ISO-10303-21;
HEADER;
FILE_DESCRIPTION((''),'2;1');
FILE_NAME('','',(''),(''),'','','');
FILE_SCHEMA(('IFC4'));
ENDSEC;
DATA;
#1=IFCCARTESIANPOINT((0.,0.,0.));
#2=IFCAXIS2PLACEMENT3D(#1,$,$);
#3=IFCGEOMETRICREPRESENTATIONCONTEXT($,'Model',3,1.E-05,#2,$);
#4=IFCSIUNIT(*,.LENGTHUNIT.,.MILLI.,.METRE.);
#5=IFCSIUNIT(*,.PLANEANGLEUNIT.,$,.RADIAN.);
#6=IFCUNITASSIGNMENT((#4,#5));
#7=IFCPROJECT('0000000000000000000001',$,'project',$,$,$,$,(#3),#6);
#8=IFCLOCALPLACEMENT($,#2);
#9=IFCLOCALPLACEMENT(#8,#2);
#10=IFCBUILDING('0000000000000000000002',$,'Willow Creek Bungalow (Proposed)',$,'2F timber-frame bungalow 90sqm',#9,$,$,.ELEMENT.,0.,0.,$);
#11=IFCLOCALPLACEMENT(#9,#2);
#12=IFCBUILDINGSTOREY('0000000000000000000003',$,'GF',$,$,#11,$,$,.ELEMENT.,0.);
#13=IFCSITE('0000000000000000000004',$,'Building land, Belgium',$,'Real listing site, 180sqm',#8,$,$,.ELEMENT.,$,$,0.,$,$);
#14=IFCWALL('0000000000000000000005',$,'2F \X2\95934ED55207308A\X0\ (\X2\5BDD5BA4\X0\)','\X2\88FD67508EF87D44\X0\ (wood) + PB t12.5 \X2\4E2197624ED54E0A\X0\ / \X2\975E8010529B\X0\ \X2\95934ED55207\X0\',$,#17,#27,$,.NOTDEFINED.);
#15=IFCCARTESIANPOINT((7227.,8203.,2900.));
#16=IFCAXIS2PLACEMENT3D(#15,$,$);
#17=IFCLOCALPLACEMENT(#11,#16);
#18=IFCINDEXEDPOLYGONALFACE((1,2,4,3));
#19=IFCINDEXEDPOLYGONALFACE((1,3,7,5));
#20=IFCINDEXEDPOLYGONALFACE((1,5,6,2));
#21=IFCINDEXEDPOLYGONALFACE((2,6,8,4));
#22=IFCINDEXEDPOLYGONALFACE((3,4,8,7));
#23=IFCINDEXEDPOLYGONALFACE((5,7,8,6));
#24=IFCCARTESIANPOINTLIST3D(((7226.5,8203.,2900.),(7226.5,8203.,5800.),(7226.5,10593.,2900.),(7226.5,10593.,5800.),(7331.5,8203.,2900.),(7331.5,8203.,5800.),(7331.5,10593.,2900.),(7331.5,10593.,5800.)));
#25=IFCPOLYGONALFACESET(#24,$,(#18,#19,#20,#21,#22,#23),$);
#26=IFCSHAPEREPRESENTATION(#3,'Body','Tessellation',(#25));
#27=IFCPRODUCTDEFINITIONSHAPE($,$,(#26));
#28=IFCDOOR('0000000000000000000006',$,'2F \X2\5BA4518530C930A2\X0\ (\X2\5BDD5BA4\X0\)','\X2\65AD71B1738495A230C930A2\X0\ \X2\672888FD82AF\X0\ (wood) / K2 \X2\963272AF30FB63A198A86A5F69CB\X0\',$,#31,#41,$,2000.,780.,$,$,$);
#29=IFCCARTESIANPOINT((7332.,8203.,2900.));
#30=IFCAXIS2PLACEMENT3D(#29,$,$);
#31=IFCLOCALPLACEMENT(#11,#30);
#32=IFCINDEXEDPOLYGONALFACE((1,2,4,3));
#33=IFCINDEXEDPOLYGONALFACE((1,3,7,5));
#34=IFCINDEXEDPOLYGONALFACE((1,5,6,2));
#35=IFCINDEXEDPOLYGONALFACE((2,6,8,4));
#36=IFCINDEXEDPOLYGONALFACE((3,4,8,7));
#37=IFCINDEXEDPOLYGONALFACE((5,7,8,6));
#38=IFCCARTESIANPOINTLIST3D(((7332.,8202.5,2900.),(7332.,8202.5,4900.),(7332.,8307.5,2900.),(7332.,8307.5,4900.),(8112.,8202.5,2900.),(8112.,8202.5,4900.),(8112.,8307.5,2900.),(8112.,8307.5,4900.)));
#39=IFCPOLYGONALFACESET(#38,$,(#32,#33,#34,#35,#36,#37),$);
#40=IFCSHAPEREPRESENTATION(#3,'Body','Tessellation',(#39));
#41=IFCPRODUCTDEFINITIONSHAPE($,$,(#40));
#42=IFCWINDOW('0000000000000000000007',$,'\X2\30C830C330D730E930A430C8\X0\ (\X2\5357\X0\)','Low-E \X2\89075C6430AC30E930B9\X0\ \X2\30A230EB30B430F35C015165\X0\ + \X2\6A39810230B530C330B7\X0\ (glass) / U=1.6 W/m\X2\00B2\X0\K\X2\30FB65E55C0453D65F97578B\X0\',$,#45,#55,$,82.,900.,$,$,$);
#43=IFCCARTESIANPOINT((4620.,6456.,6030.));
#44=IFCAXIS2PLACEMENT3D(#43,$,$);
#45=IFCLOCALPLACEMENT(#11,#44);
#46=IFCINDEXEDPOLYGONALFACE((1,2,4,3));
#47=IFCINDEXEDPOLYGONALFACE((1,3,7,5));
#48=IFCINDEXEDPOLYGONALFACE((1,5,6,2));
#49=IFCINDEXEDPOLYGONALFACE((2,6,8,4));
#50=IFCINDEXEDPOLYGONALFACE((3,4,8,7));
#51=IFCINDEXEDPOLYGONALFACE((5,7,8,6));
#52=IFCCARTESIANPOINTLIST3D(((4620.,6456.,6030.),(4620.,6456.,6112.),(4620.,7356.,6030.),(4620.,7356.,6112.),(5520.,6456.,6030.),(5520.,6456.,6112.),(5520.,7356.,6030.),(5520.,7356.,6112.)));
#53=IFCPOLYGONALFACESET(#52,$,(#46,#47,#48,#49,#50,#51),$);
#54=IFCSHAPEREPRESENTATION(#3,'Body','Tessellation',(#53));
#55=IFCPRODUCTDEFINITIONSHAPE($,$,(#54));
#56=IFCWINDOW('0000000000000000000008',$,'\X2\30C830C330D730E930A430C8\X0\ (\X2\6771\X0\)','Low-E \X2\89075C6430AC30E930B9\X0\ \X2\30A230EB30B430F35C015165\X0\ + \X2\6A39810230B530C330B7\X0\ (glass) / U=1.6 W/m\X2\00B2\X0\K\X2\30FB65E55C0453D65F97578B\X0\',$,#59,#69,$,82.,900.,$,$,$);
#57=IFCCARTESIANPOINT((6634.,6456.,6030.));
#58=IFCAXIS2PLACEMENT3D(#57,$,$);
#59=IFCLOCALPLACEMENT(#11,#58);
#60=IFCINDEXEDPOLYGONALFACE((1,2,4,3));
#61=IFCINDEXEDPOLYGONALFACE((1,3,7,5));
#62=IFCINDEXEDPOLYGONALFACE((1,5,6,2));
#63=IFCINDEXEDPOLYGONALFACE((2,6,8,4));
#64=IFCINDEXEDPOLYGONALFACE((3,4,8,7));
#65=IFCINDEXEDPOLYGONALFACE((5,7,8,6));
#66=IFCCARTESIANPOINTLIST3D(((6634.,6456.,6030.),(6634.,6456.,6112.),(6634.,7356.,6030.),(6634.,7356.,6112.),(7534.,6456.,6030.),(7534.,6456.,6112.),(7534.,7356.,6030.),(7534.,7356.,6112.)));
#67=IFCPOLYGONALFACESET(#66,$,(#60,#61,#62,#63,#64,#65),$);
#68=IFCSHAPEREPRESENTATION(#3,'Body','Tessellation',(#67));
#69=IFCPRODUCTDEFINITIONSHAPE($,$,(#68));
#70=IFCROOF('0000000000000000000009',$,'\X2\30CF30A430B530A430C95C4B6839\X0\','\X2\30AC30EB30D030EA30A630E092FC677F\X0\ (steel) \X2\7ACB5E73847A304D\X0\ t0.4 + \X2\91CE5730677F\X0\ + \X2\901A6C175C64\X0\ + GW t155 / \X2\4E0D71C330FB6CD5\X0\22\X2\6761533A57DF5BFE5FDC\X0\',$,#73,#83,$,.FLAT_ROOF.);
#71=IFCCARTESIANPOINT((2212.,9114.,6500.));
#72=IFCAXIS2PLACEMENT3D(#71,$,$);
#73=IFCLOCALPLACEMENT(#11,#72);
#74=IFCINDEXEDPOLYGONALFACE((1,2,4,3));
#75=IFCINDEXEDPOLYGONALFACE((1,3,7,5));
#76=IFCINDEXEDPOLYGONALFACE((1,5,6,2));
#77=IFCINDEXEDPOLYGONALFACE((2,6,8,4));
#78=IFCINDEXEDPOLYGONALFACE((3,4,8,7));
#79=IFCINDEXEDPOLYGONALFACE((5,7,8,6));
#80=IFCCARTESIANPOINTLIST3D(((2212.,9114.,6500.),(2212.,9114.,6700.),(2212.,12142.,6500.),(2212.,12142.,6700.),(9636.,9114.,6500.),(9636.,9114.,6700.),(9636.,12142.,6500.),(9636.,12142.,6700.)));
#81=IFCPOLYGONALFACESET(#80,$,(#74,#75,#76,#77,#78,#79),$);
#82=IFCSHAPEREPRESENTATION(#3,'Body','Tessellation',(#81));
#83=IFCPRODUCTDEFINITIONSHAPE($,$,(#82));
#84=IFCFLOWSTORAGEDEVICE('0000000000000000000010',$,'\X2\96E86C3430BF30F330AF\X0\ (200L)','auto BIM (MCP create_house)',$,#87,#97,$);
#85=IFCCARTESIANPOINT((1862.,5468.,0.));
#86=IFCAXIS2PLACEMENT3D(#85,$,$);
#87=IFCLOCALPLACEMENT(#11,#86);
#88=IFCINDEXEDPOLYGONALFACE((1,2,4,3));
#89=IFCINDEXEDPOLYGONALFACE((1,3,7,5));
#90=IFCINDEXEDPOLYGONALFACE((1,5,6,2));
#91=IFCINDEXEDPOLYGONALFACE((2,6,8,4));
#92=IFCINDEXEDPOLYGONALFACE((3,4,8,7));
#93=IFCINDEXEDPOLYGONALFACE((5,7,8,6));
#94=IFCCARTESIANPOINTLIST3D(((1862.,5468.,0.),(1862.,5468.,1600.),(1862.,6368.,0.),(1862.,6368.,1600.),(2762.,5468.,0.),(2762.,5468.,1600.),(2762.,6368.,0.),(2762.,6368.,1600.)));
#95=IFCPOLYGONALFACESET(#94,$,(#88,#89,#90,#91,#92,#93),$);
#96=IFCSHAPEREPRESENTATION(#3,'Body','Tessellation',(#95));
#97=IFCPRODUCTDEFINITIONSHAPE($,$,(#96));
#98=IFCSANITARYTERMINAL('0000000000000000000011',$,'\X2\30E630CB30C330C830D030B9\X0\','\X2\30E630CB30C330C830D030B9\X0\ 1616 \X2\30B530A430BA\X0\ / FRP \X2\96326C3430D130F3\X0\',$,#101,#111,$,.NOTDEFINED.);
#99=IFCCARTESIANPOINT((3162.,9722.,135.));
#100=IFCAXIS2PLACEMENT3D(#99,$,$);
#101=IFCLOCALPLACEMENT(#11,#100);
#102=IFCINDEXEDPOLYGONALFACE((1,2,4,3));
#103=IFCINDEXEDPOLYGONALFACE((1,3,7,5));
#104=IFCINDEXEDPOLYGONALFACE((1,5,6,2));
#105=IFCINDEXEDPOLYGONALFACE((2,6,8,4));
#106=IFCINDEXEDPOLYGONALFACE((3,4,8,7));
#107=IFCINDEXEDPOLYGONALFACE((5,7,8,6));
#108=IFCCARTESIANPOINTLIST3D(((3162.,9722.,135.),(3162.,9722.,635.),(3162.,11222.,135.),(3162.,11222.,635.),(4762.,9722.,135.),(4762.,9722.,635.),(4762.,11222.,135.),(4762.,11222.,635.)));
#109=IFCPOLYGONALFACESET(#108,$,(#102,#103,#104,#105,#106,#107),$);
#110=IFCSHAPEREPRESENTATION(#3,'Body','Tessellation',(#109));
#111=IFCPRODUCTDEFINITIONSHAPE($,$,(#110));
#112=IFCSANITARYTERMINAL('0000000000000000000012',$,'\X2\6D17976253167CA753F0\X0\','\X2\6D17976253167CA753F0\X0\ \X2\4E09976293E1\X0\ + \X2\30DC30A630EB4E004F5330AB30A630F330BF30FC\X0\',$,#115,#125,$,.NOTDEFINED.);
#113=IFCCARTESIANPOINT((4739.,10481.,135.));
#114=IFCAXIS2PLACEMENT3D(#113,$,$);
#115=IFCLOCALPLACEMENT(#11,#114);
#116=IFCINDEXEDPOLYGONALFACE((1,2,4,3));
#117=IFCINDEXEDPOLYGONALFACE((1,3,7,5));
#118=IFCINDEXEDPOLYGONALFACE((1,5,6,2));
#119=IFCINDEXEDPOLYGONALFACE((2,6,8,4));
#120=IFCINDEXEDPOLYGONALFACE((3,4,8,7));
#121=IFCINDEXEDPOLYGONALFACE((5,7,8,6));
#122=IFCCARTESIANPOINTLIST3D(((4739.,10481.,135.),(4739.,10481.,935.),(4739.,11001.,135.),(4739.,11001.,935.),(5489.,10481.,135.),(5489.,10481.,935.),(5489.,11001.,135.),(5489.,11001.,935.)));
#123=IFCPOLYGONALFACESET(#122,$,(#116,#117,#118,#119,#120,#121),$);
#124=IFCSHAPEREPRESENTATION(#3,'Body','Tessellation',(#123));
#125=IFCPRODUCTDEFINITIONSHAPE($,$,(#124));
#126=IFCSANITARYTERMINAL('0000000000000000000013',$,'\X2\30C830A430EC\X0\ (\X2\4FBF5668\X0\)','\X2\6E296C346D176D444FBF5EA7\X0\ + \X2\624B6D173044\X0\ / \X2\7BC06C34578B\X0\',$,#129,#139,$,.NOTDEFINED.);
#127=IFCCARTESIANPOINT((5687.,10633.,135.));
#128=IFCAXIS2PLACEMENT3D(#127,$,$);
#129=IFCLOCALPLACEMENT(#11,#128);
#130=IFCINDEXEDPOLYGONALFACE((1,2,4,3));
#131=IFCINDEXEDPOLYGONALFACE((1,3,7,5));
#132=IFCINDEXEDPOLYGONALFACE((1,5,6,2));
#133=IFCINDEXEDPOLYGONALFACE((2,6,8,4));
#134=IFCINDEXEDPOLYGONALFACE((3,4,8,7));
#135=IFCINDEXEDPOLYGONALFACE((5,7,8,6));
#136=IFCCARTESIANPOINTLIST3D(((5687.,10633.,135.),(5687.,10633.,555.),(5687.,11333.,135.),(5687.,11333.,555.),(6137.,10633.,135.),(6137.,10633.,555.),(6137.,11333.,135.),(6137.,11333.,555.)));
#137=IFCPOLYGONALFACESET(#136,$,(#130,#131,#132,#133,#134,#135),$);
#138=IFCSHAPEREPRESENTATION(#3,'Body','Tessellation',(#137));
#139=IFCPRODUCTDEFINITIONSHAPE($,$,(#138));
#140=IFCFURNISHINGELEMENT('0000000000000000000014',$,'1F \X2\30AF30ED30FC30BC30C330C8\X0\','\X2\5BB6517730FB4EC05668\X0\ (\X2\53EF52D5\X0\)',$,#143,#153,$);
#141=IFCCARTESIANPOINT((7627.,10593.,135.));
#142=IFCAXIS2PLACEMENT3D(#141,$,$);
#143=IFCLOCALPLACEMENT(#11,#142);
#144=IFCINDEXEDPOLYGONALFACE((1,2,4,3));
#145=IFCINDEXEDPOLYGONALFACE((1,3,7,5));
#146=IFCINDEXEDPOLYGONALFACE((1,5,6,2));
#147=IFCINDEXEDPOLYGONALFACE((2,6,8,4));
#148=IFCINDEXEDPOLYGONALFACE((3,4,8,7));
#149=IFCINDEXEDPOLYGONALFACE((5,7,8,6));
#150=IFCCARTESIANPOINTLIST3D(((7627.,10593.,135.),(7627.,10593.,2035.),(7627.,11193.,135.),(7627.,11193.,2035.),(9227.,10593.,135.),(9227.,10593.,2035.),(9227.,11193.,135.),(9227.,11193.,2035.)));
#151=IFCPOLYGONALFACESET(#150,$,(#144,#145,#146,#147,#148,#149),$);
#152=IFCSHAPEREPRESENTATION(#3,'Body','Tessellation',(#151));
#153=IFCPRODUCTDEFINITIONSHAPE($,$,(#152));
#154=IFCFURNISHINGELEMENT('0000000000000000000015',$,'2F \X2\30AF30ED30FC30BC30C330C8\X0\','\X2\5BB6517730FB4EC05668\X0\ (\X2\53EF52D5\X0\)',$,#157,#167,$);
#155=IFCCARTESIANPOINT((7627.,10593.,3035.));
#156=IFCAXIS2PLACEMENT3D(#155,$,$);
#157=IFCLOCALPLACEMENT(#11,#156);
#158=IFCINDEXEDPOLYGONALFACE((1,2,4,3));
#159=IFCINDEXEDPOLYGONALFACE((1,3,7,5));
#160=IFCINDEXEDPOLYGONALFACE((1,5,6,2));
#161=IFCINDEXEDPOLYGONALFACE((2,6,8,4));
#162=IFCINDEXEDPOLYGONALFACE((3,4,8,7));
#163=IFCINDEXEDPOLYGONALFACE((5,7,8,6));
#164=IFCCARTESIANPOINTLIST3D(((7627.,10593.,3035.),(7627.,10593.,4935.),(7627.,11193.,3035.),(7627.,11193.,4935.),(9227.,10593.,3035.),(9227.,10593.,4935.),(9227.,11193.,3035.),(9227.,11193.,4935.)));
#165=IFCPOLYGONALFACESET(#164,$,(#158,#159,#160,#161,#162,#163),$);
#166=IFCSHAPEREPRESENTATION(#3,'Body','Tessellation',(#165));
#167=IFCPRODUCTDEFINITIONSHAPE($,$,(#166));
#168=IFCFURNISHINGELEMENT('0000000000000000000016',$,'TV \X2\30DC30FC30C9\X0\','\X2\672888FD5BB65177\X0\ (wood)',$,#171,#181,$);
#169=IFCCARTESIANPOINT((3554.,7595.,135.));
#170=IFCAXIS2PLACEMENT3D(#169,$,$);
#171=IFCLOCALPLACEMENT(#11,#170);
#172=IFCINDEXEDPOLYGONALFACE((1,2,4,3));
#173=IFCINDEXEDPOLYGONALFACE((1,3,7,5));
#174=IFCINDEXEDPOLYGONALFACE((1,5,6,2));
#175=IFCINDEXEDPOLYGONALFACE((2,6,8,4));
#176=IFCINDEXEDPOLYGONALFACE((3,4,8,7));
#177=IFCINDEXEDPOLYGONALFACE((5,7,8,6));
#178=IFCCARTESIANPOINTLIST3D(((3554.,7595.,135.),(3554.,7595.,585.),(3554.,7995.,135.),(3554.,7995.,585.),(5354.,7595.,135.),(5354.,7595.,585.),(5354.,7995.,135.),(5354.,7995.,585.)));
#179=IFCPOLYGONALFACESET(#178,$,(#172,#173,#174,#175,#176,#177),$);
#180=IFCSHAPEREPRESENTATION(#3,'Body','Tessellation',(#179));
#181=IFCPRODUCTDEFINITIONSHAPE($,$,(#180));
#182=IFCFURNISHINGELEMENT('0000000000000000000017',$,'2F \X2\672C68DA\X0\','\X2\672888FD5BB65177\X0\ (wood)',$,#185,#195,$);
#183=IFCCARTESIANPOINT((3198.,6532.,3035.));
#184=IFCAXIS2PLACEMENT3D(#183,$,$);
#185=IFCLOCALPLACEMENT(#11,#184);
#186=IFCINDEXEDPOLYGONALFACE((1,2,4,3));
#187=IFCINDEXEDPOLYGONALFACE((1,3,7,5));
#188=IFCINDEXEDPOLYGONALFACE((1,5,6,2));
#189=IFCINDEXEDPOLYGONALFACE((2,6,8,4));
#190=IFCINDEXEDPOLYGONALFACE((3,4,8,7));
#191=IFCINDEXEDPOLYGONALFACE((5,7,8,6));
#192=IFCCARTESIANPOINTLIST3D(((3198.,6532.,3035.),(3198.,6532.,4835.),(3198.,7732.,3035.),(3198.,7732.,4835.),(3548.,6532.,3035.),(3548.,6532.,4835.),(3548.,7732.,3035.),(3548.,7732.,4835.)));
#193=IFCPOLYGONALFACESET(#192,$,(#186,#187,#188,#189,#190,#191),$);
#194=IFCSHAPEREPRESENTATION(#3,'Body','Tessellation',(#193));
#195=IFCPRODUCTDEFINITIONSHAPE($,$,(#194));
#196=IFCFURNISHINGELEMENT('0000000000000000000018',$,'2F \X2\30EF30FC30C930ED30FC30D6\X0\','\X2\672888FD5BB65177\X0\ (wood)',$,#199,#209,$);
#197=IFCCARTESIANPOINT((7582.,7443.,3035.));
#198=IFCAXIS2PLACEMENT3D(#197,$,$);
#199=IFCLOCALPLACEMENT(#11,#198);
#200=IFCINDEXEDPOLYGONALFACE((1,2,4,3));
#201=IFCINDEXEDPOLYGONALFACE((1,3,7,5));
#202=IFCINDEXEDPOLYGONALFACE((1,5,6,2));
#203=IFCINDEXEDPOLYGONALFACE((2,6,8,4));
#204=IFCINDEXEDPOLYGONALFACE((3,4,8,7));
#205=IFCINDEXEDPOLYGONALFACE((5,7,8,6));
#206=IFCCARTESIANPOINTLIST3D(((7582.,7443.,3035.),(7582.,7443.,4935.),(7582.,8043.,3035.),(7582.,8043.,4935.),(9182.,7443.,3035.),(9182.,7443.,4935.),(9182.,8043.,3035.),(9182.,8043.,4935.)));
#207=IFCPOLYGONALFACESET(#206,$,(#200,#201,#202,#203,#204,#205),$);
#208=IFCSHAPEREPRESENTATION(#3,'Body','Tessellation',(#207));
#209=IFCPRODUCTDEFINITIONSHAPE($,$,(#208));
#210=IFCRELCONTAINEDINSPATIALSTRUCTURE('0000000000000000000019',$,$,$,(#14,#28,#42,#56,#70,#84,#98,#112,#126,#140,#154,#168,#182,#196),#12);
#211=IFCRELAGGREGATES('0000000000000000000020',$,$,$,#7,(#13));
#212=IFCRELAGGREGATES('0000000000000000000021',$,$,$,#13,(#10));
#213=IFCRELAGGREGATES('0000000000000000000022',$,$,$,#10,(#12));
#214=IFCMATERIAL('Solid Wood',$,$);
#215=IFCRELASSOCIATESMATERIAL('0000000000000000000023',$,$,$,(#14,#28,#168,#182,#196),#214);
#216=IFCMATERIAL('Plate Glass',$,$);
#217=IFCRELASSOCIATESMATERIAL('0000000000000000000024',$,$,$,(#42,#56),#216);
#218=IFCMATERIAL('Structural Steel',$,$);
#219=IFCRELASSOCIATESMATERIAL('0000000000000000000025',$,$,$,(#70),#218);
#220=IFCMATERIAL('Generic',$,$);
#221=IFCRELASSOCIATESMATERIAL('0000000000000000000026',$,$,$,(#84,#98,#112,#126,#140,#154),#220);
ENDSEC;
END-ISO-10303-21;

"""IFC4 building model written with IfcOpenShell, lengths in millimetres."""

from ifc_helpers import new_model, si_unit, frame, frame_2d, origin, place, context, project, spatial, rectangle, extrude, material, element, save


model = new_model("IFC4")

# Units and contexts
model_context = context("Model", 3, precision=1e-05, world=origin())
ifc_project = project(units=[si_unit("LENGTHUNIT", "METRE", prefix="MILLI"), si_unit("PLANEANGLEUNIT", "RADIAN")], contexts=[model_context])

# Site, building, storey
site_placement = place(None, origin())
site = spatial("IfcSite", under=ifc_project, at=site_placement, Name="Building land, Belgium", ObjectType="Real listing site, 180sqm", CompositionType="ELEMENT", RefElevation=0.0)
building_placement = place(site_placement, origin())
building = spatial("IfcBuilding", under=site, at=building_placement, Name="Willow Creek Bungalow (Proposed)", ObjectType="2F timber-frame bungalow 90sqm", CompositionType="ELEMENT", ElevationOfRefHeight=0.0, ElevationOfTerrain=0.0)
storey_placement = place(building_placement, origin())
storey = spatial("IfcBuildingStorey", under=building, at=storey_placement, Name="GF", CompositionType="ELEMENT", Elevation=0.0)

# Shared definitions
ifc_material_1 = material(Name="Solid Wood")
ifc_material_2 = material(Name="Plate Glass")

# Wall
wall_1_placement = place(storey_placement, frame((7227.0, 8203.0, 2900.0)))
element("IfcWall", 1, at=wall_1_placement, inside=storey, material=ifc_material_1, Name="2F 間仕切り (寝室)", Description="製材軸組 (wood) + PB t12.5 両面仕上 / 非耐力 間仕切", PredefinedType="NOTDEFINED", context=model_context, shape_type="SweptSolid", body=[
    extrude(rectangle(XDim=105.0, YDim=2390.0, at=frame_2d((52.0, 1195.0))), frame((7227.0, 8203.0, 2900.0)), (0.0, 0.0, 1.0), 2900.0),
])

# Door
door_1_placement = place(storey_placement, frame((7332.0, 8203.0, 2900.0)))
element("IfcDoor", 2, at=door_1_placement, inside=storey, material=ifc_material_1, Name="2F 室内ドア (寝室)", Description="断熱玄関ドア 木製芯 (wood) / K2 防犯・採風機構", OverallHeight=2000.0, OverallWidth=780.0, context=model_context, shape_type="SweptSolid", body=[
    extrude(rectangle(XDim=780.0, YDim=105.0, at=frame_2d((390.0, 52.0))), frame((7332.0, 8203.0, 2900.0)), (0.0, 0.0, 1.0), 2000.0),
])

# Windows
window_1_placement = place(storey_placement, frame((4620.0, 6456.0, 6030.0)))
element("IfcWindow", 3, at=window_1_placement, inside=storey, material=ifc_material_2, Name="トップライト (南)", Description="Low-E 複層ガラス アルゴン封入 + 樹脂サッシ (glass) / U=1.6 W/m²K・日射取得型", OverallHeight=82.0, OverallWidth=900.0, context=model_context, shape_type="SweptSolid", body=[
    extrude(rectangle(XDim=900.0, YDim=900.0, at=frame_2d((450.0, 450.0))), frame((4620.0, 6456.0, 6030.0)), (0.0, 0.0, 1.0), 82.0),
])
window_2_placement = place(storey_placement, frame((6634.0, 6456.0, 6030.0)))
element("IfcWindow", 4, at=window_2_placement, inside=storey, material=ifc_material_2, Name="トップライト (東)", Description="Low-E 複層ガラス アルゴン封入 + 樹脂サッシ (glass) / U=1.6 W/m²K・日射取得型", OverallHeight=82.0, OverallWidth=900.0, context=model_context, shape_type="SweptSolid", body=[
    extrude(rectangle(XDim=900.0, YDim=900.0, at=frame_2d((450.0, 450.0))), frame((6634.0, 6456.0, 6030.0)), (0.0, 0.0, 1.0), 82.0),
])

# Roof
ifc_material_3 = material(Name="Structural Steel")
roof_placement = place(storey_placement, frame((2212.0, 9114.0, 6500.0)))
element("IfcRoof", 5, at=roof_placement, inside=storey, material=ifc_material_3, Name="ハイサイド屋根", Description="ガルバリウム鋼板 (steel) 立平葺き t0.4 + 野地板 + 通気層 + GW t155 / 不燃・法22条区域対応", PredefinedType="FLAT_ROOF", context=model_context, shape_type="SweptSolid", body=[
    extrude(rectangle(XDim=7424.0, YDim=3028.0, at=frame_2d((3712.0, 1514.0))), frame((2212.0, 9114.0, 6500.0)), (0.0, 0.0, 1.0), 200.0),
])

# Flow storage device
ifc_material_4 = material(Name="Generic")
flow_storage_device_placement = place(storey_placement, frame((1862.0, 5468.0, 0.0)))
element("IfcFlowStorageDevice", 6, at=flow_storage_device_placement, inside=storey, material=ifc_material_4, Name="雨水タンク (200L)", Description="auto BIM (MCP create_house)", context=model_context, shape_type="SweptSolid", body=[
    extrude(rectangle(XDim=900.0, YDim=900.0, at=frame_2d((450.0, 450.0))), frame((1862.0, 5468.0, 0.0)), (0.0, 0.0, 1.0), 1600.0),
])

# Sanitary terminals
sanitary_terminal_1_placement = place(storey_placement, frame((3162.0, 9722.0, 135.0)))
element("IfcSanitaryTerminal", 7, at=sanitary_terminal_1_placement, inside=storey, material=ifc_material_4, Name="ユニットバス", Description="ユニットバス 1616 サイズ / FRP 防水パン", PredefinedType="NOTDEFINED", context=model_context, shape_type="SweptSolid", body=[
    extrude(rectangle(XDim=1600.0, YDim=1500.0, at=frame_2d((800.0, 750.0))), frame((3162.0, 9722.0, 135.0)), (0.0, 0.0, 1.0), 500.0),
])
sanitary_terminal_2_placement = place(storey_placement, frame((4739.0, 10481.0, 135.0)))
element("IfcSanitaryTerminal", 8, at=sanitary_terminal_2_placement, inside=storey, material=ifc_material_4, Name="洗面化粧台", Description="洗面化粧台 三面鏡 + ボウル一体カウンター", PredefinedType="NOTDEFINED", context=model_context, shape_type="SweptSolid", body=[
    extrude(rectangle(XDim=750.0, YDim=520.0, at=frame_2d((375.0, 260.0))), frame((4739.0, 10481.0, 135.0)), (0.0, 0.0, 1.0), 800.0),
])
sanitary_terminal_3_placement = place(storey_placement, frame((5687.0, 10633.0, 135.0)))
element("IfcSanitaryTerminal", 9, at=sanitary_terminal_3_placement, inside=storey, material=ifc_material_4, Name="トイレ (便器)", Description="温水洗浄便座 + 手洗い / 節水型", PredefinedType="NOTDEFINED", context=model_context, shape_type="SweptSolid", body=[
    extrude(rectangle(XDim=450.0, YDim=700.0, at=frame_2d((225.0, 350.0))), frame((5687.0, 10633.0, 135.0)), (0.0, 0.0, 1.0), 420.0),
])

# Furnishing elements
furnishing_1_placement = place(storey_placement, frame((7627.0, 10593.0, 135.0)))
element("IfcFurnishingElement", 10, at=furnishing_1_placement, inside=storey, material=ifc_material_4, Name="1F クローゼット", Description="家具・什器 (可動)", context=model_context, shape_type="SweptSolid", body=[
    extrude(rectangle(XDim=1600.0, YDim=600.0, at=frame_2d((800.0, 300.0))), frame((7627.0, 10593.0, 135.0)), (0.0, 0.0, 1.0), 1900.0),
])
furnishing_2_placement = place(storey_placement, frame((7627.0, 10593.0, 3035.0)))
element("IfcFurnishingElement", 11, at=furnishing_2_placement, inside=storey, material=ifc_material_4, Name="2F クローゼット", Description="家具・什器 (可動)", context=model_context, shape_type="SweptSolid", body=[
    extrude(rectangle(XDim=1600.0, YDim=600.0, at=frame_2d((800.0, 300.0))), frame((7627.0, 10593.0, 3035.0)), (0.0, 0.0, 1.0), 1900.0),
])
furnishing_3_placement = place(storey_placement, frame((3554.0, 7595.0, 135.0)))
element("IfcFurnishingElement", 12, at=furnishing_3_placement, inside=storey, material=ifc_material_1, Name="TV ボード", Description="木製家具 (wood)", context=model_context, shape_type="SweptSolid", body=[
    extrude(rectangle(XDim=1800.0, YDim=400.0, at=frame_2d((900.0, 200.0))), frame((3554.0, 7595.0, 135.0)), (0.0, 0.0, 1.0), 450.0),
])
furnishing_4_placement = place(storey_placement, frame((3198.0, 6532.0, 3035.0)))
element("IfcFurnishingElement", 13, at=furnishing_4_placement, inside=storey, material=ifc_material_1, Name="2F 本棚", Description="木製家具 (wood)", context=model_context, shape_type="SweptSolid", body=[
    extrude(rectangle(XDim=350.0, YDim=1200.0, at=frame_2d((175.0, 600.0))), frame((3198.0, 6532.0, 3035.0)), (0.0, 0.0, 1.0), 1800.0),
])
furnishing_5_placement = place(storey_placement, frame((7582.0, 7443.0, 3035.0)))
element("IfcFurnishingElement", 14, at=furnishing_5_placement, inside=storey, material=ifc_material_1, Name="2F ワードローブ", Description="木製家具 (wood)", context=model_context, shape_type="SweptSolid", body=[
    extrude(rectangle(XDim=1600.0, YDim=600.0, at=frame_2d((800.0, 300.0))), frame((7582.0, 7443.0, 3035.0)), (0.0, 0.0, 1.0), 1900.0),
])

save(model, "model.ifc")
